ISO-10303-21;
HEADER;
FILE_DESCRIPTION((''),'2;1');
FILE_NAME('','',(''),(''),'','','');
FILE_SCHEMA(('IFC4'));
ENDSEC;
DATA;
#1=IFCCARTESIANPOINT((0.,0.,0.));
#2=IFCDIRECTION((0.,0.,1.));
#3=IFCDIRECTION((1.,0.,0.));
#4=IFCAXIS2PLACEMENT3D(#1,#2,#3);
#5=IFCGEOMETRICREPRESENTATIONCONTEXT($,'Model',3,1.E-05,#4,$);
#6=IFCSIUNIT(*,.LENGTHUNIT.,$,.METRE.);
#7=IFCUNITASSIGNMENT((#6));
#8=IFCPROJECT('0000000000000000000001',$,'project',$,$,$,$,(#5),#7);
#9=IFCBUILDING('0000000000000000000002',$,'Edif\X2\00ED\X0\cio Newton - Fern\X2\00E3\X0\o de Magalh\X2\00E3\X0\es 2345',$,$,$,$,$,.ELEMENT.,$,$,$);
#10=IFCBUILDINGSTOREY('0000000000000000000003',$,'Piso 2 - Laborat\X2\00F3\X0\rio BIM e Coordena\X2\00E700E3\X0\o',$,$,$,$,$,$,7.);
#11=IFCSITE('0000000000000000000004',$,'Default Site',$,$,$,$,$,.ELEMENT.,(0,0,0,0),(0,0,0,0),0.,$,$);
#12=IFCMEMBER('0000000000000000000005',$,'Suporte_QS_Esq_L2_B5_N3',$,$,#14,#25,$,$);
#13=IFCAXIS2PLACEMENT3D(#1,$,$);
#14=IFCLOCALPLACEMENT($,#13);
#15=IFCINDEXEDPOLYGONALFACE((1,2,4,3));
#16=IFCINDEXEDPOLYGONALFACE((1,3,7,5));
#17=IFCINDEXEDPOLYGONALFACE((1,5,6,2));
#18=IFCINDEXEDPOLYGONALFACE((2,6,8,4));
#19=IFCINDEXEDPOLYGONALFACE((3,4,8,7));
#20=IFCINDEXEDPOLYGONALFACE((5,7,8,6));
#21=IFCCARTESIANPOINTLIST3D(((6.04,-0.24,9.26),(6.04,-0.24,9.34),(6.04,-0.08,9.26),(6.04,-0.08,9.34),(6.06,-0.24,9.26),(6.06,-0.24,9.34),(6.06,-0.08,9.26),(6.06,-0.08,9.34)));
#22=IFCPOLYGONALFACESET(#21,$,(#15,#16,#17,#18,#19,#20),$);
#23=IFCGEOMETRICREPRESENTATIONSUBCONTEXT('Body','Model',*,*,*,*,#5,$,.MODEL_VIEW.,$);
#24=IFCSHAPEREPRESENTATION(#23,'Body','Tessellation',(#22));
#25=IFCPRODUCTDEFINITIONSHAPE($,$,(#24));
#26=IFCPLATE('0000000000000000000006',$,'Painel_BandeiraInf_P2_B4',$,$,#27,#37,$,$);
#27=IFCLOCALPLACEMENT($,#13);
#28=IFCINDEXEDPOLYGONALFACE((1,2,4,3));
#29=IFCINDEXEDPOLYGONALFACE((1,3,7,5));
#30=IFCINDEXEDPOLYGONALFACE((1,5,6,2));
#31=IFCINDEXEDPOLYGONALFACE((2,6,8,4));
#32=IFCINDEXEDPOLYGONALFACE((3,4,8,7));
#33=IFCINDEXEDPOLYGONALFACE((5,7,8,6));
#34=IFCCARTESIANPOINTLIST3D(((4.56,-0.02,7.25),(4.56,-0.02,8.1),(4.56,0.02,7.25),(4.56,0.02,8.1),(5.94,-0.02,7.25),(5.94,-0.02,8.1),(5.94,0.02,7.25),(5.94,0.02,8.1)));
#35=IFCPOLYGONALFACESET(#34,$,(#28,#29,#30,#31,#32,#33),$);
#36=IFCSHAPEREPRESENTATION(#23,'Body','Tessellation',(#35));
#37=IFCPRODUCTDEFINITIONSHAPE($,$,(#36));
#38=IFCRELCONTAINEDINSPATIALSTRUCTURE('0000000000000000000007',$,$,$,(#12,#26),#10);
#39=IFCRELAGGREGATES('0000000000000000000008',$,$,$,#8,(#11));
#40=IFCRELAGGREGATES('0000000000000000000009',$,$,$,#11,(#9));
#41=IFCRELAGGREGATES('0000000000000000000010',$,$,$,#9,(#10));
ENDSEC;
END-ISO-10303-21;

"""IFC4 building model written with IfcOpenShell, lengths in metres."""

from ifc_helpers import new_model, si_unit, frame, frame_2d, origin_with_axes, place, context, subcontext, project, spatial, rectangle, extrude, element, save


model = new_model("IFC4")

# Units and contexts
model_context = context("Model", 3, precision=1e-05, world=origin_with_axes())
body_context = subcontext(model_context, "Body", "Model", "MODEL_VIEW")
ifc_project = project(units=[si_unit("LENGTHUNIT", "METRE")], contexts=[model_context])

# Site, building, storey
site = spatial("IfcSite", under=ifc_project, Name="Default Site", CompositionType="ELEMENT", RefLatitude=(0, 0, 0, 0), RefLongitude=(0, 0, 0, 0), RefElevation=0.0)
building = spatial("IfcBuilding", under=site, Name="Edifício Newton - Fernão de Magalhães 2345", CompositionType="ELEMENT")
storey = spatial("IfcBuildingStorey", under=building, Name="Piso 2 - Laboratório BIM e Coordenação", Elevation=7.0)

# Member
for number, where, z_axis, x_axis, name in (
    (1, (6.04, -0.24, 9.26), (0.0, 0.0, 1.0), (1.0, 0.0, 0.0), "Suporte_QS_Esq_L2_B5_N3"),
):
    element("IfcMember", number, at=place(None, frame(where, z_axis=z_axis, x_axis=x_axis)), inside=storey, Name=name, context=body_context, shape_type="SweptSolid", body=[
        extrude(rectangle(XDim=0.02, YDim=0.16, at=frame_2d((0.01, 0.08))), origin_with_axes(), (0.0, 0.0, 1.0), 0.08),
    ])

# Plate
plate_placement = place(None, frame((4.56, -0.02, 7.25), z_axis=(0.0, 0.0, 1.0), x_axis=(1.0, 0.0, 0.0)))
element("IfcPlate", 2, at=plate_placement, inside=storey, Name="Painel_BandeiraInf_P2_B4", context=body_context, shape_type="SweptSolid", body=[
    extrude(rectangle(XDim=1.38, YDim=0.04, at=frame_2d((0.69, 0.02))), origin_with_axes(), (0.0, 0.0, 1.0), 0.85),
])

save(model, "model.ifc")
